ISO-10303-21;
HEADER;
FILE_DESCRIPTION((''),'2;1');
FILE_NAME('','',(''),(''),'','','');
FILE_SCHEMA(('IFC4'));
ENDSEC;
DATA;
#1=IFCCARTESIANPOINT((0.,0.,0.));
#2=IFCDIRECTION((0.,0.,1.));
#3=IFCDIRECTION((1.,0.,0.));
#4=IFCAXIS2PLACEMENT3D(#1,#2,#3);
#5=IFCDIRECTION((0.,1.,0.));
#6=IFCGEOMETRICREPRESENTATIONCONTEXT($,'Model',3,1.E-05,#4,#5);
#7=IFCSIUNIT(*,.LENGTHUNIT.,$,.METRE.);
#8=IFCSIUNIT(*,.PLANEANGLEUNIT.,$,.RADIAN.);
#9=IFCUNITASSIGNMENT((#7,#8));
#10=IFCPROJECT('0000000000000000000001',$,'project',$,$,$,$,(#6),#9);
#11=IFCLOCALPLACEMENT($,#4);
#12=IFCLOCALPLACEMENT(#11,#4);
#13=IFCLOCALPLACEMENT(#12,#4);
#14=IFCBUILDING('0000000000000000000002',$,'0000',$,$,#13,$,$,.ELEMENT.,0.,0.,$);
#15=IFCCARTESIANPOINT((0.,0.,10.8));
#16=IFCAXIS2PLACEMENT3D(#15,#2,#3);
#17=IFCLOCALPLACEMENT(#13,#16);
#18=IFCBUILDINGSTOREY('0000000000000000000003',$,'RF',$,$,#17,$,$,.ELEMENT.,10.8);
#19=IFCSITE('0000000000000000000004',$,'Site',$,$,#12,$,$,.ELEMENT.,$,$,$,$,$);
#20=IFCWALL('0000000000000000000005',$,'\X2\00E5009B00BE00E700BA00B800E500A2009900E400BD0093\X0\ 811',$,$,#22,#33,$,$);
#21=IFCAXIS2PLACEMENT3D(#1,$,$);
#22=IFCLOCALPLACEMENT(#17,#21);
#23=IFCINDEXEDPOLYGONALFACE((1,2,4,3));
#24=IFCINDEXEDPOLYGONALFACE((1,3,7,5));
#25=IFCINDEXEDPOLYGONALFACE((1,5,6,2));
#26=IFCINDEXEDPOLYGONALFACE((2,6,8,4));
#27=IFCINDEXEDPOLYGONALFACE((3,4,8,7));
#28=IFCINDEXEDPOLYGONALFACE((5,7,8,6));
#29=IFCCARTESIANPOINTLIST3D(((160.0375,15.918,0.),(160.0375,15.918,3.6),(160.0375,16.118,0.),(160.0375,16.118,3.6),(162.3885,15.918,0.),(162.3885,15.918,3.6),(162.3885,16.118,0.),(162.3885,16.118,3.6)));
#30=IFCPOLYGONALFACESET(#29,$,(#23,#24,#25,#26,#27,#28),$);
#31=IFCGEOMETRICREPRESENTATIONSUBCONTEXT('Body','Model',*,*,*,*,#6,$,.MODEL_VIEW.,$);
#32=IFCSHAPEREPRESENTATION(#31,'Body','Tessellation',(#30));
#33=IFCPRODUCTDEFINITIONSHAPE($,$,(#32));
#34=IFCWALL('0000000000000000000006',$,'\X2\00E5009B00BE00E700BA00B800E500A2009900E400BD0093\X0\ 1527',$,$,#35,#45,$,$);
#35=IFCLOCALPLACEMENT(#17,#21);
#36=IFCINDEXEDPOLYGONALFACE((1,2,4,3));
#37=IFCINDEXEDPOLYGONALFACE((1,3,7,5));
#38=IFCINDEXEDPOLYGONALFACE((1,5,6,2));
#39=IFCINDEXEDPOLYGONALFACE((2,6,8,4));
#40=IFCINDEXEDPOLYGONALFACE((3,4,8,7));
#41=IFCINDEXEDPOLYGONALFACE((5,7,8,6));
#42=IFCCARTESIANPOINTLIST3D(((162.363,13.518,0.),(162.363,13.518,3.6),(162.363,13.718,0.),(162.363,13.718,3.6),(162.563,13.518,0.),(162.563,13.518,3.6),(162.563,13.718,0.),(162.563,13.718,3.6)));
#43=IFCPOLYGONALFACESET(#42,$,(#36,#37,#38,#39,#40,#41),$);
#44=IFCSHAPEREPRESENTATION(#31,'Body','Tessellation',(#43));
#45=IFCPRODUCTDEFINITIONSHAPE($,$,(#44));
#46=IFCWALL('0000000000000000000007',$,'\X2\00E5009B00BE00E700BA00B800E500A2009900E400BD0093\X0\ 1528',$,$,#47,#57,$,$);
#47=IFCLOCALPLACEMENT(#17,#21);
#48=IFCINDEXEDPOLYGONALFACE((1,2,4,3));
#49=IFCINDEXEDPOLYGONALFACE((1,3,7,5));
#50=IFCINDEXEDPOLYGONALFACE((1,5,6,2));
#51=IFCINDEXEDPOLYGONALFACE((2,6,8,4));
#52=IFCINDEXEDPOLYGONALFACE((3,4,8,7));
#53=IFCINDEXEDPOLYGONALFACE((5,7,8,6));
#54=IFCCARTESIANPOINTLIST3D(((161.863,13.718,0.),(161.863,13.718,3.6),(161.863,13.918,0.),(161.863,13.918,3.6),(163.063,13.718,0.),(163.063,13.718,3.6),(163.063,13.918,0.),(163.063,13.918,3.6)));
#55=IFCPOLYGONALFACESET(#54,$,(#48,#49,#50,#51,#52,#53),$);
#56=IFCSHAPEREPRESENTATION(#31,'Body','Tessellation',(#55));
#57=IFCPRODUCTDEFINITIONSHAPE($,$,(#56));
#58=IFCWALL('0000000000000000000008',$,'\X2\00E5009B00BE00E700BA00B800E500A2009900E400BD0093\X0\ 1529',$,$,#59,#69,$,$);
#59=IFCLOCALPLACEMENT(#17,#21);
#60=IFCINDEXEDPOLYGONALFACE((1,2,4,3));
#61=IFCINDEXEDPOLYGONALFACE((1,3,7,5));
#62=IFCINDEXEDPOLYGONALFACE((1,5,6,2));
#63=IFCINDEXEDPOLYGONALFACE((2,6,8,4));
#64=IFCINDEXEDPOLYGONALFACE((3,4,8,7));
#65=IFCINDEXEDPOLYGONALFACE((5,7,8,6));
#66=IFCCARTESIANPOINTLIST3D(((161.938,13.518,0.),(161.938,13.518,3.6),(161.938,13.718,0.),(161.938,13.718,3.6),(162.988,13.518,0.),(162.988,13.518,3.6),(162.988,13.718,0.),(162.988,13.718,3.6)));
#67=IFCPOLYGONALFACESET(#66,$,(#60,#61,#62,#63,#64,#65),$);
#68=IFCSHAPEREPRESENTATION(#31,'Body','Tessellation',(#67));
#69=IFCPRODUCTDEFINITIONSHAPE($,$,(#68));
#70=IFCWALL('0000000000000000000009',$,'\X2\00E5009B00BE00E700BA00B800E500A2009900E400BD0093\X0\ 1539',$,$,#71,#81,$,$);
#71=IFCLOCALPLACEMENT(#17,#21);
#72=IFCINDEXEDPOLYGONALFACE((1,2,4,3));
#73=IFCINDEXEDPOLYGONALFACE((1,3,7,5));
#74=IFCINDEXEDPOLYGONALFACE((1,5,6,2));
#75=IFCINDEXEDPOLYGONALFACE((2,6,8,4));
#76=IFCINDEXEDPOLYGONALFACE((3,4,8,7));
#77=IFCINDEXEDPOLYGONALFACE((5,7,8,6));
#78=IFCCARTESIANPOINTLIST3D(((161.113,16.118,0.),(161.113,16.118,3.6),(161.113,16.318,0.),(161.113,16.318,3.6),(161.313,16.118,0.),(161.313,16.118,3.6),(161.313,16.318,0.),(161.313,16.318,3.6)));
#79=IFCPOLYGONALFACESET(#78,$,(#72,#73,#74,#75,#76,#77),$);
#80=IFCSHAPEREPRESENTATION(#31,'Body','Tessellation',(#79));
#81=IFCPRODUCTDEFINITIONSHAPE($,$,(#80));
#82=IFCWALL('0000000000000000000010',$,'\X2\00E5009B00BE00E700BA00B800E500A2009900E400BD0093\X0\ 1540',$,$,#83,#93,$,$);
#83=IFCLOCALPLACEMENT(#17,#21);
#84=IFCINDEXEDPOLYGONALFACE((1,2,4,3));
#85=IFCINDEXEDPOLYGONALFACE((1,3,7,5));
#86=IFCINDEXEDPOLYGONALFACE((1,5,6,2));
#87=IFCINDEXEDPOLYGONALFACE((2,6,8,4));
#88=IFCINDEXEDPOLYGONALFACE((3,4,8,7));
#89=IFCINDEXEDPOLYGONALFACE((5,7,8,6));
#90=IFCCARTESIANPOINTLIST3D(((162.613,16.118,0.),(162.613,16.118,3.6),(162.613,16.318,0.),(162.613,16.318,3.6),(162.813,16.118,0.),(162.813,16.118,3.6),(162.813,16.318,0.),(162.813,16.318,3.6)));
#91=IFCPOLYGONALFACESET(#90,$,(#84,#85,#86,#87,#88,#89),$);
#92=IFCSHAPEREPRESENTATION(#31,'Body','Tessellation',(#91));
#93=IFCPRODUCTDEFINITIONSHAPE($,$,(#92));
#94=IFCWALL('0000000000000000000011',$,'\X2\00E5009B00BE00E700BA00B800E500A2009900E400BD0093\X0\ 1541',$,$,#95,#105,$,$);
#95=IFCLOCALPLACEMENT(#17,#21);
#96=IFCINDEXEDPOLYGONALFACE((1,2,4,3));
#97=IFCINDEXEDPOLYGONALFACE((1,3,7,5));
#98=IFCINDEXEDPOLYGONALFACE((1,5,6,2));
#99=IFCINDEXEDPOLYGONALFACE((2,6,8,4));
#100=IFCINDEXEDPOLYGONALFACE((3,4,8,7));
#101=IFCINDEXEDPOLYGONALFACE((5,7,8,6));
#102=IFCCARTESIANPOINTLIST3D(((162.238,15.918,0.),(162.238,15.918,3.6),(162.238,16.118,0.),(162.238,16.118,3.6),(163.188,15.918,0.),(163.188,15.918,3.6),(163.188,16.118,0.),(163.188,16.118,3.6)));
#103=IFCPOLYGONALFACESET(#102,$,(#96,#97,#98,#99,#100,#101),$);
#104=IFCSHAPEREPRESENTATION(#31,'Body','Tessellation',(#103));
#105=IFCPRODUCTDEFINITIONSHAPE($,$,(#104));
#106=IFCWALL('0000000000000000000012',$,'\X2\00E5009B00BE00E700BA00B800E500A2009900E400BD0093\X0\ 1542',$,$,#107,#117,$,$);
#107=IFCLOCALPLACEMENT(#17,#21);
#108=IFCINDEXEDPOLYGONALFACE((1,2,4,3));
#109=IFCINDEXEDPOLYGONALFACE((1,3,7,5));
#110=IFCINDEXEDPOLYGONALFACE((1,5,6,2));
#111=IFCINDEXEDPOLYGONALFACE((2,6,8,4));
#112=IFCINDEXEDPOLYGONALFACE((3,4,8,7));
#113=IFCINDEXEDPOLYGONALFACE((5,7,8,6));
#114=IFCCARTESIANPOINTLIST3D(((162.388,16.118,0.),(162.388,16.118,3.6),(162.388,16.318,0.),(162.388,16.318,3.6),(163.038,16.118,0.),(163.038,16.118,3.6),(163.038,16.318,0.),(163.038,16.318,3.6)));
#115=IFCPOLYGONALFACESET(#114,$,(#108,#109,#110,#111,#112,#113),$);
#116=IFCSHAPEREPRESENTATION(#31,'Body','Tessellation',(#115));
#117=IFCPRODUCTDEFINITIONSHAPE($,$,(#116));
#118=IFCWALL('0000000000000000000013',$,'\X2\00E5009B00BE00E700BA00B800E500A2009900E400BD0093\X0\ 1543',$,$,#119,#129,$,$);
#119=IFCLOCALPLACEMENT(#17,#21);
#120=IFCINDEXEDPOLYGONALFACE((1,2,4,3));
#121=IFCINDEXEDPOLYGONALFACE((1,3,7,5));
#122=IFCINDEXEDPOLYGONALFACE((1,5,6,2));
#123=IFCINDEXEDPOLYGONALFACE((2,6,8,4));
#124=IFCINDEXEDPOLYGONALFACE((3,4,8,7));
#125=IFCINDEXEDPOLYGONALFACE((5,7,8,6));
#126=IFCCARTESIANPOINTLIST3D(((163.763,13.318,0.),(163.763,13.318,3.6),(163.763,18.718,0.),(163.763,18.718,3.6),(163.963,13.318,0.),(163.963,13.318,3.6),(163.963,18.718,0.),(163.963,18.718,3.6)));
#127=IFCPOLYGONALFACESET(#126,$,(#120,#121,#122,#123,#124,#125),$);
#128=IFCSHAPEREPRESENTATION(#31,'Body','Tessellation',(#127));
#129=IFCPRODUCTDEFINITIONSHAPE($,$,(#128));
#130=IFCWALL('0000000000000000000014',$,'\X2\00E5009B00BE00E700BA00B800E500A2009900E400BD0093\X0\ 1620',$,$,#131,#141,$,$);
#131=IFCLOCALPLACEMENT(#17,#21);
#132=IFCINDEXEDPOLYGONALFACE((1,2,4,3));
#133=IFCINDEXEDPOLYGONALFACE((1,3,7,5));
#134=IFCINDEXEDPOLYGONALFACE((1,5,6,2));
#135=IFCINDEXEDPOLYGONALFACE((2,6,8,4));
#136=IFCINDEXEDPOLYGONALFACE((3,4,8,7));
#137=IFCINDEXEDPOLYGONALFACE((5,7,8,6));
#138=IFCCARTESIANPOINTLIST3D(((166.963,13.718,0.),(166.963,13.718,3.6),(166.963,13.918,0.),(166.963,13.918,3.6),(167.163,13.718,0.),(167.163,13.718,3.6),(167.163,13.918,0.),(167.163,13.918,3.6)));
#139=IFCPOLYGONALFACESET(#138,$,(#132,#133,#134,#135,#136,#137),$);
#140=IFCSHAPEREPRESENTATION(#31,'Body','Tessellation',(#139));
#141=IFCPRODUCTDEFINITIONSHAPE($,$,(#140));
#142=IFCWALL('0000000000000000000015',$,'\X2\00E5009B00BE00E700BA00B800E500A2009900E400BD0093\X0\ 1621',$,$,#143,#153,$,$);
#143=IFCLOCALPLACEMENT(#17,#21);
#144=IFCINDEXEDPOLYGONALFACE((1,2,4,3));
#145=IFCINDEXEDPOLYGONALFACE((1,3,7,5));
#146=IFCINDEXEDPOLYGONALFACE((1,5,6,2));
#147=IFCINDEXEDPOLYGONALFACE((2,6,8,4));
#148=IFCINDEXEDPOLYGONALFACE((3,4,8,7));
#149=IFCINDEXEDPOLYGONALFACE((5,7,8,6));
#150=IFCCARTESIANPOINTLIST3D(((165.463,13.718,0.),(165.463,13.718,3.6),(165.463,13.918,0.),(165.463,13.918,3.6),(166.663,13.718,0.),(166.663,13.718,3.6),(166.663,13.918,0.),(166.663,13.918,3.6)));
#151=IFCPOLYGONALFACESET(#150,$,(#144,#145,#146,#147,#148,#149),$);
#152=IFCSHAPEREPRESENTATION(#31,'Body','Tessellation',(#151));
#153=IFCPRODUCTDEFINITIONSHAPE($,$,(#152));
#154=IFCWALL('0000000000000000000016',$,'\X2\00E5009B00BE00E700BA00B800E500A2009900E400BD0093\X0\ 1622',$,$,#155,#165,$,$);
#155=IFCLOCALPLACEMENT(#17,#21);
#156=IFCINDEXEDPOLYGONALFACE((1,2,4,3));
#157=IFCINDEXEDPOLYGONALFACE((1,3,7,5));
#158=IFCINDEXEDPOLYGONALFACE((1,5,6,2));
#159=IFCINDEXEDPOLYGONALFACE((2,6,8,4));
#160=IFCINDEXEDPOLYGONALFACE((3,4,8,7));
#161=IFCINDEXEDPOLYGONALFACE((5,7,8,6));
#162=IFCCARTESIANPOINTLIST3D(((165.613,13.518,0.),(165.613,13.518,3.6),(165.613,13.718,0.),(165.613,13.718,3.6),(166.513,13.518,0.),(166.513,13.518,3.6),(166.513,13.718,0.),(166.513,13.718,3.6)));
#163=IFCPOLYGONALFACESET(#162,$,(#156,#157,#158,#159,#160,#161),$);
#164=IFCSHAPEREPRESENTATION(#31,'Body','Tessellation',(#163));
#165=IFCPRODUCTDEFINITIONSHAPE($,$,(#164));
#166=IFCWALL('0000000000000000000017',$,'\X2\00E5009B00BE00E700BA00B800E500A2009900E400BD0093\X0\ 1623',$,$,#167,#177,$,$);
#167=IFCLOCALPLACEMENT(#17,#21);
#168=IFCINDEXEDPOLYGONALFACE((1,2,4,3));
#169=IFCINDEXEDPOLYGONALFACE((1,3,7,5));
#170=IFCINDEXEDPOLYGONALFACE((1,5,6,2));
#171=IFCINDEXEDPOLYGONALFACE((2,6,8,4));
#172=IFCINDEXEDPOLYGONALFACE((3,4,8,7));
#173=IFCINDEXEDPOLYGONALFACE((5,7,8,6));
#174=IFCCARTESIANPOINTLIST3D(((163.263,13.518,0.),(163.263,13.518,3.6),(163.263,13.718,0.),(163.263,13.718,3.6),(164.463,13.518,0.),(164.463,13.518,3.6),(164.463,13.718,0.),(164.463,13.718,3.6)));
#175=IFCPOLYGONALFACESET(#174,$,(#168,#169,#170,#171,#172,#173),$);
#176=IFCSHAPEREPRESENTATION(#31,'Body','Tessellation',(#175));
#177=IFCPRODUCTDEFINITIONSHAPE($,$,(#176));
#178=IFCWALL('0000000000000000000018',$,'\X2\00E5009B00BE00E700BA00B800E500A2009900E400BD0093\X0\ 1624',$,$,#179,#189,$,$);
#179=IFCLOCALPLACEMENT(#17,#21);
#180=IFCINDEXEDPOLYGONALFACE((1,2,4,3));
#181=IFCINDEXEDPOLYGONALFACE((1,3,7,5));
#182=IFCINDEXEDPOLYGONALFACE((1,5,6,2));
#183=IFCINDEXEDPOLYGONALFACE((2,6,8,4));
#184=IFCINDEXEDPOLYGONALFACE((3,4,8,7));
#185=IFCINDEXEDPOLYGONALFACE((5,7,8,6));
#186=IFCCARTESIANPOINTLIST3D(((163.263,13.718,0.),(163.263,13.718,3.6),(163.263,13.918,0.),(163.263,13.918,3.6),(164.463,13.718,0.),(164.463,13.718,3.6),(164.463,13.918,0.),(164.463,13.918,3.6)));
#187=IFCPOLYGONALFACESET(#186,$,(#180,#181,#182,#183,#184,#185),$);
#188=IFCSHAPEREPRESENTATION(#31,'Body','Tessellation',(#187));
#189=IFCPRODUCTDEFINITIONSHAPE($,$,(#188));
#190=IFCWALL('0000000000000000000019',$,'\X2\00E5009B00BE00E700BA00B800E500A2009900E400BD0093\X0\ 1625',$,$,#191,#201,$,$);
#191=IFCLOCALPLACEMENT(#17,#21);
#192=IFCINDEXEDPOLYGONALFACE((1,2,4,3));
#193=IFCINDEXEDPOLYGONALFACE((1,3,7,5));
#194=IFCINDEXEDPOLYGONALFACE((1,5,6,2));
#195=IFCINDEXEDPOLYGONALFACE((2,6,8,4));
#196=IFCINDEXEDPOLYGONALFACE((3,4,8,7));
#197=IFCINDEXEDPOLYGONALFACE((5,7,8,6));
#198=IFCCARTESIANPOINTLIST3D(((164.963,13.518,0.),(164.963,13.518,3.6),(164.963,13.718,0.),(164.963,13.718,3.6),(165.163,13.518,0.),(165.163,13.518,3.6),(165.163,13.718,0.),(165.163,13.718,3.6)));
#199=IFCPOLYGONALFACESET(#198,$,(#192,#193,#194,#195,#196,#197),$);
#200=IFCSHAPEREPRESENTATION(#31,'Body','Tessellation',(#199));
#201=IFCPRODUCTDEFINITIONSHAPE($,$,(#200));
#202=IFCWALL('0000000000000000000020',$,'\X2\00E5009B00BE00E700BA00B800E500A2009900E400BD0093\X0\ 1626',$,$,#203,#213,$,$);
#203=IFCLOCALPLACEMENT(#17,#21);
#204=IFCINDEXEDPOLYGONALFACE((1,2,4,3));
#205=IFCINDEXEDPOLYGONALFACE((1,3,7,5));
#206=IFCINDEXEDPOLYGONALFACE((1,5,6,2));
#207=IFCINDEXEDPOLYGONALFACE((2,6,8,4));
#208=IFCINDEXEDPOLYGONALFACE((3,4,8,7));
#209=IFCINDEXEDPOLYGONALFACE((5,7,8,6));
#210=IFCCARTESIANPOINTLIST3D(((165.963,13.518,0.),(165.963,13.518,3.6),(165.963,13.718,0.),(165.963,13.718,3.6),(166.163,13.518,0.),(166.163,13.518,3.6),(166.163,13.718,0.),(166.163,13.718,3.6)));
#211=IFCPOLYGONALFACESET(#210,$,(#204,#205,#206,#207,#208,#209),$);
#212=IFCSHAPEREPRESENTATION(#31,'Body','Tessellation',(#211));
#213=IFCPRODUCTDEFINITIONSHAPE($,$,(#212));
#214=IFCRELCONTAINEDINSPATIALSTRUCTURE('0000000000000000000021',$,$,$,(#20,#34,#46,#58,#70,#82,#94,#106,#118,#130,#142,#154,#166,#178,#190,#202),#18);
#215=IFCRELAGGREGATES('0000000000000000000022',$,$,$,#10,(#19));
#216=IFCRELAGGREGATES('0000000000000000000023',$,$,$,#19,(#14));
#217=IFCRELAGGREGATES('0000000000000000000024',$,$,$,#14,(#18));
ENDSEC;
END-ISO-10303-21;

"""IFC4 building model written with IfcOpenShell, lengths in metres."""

from ifc_helpers import new_model, si_unit, direction, frame, frame_2d, origin_with_axes, place, context, subcontext, project, spatial, rectangle, extrude, element, save


model = new_model("IFC4")

# Units and contexts
model_context = context("Model", 3, precision=1e-05, world=origin_with_axes(), true_north=direction((0.0, 1.0, 0.0)))
body_context = subcontext(model_context, "Body", "Model", "MODEL_VIEW")
ifc_project = project(units=[si_unit("LENGTHUNIT", "METRE"), si_unit("PLANEANGLEUNIT", "RADIAN")], contexts=[model_context])

# Site, building, storey
placement = place(None, origin_with_axes())
site_placement = place(placement, origin_with_axes())
site = spatial("IfcSite", under=ifc_project, at=site_placement, Name="Site", CompositionType="ELEMENT")
building_placement = place(site_placement, origin_with_axes())
building = spatial("IfcBuilding", under=site, at=building_placement, Name="0000", CompositionType="ELEMENT", ElevationOfRefHeight=0.0, ElevationOfTerrain=0.0)
storey_placement = place(building_placement, frame((0.0, 0.0, 10.8), z_axis=(0.0, 0.0, 1.0), x_axis=(1.0, 0.0, 0.0)))
storey = spatial("IfcBuildingStorey", under=building, at=storey_placement, Name="RF", CompositionType="ELEMENT", Elevation=10.8)

# Walls
wall_1_placement = place(storey_placement, frame((161.213, 16.018, 0.0), z_axis=(0.0, 0.0, 1.0), x_axis=(-1.0, 0.0, 0.0)))
element("IfcWall", 1, at=wall_1_placement, inside=storey, Name="å\u009b¾çº¸å¢\u0099ä½\u0093 811", context=body_context, shape_type="SweptSolid", body=[
    extrude(rectangle(XDim=2.351, YDim=0.2, at=frame_2d((0.0, 0.0), x_axis=(1.0, 0.0, 0.0))), frame((0.0, 0.0, 0.0), z_axis=(0.0, 0.0, 1.0)), (0.0, 0.0, 1.0), 3.6),
])
wall_2_placement = place(storey_placement, frame((162.463, 13.618, 0.0), z_axis=(0.0, 0.0, 1.0), x_axis=(0.0, 1.0, 0.0)))
element("IfcWall", 2, at=wall_2_placement, inside=storey, Name="å\u009b¾çº¸å¢\u0099ä½\u0093 1527", context=body_context, shape_type="SweptSolid", body=[
    extrude(rectangle(XDim=0.2, YDim=0.2, at=frame_2d((0.0, 0.0), x_axis=(1.0, 0.0, 0.0))), frame((0.0, 0.0, 0.0), z_axis=(0.0, 0.0, 1.0)), (0.0, 0.0, 1.0), 3.6),
])
wall_3_placement = place(storey_placement, frame((162.463, 13.818, 0.0), z_axis=(0.0, 0.0, 1.0), x_axis=(1.0, 0.0, 0.0)))
element("IfcWall", 3, at=wall_3_placement, inside=storey, Name="å\u009b¾çº¸å¢\u0099ä½\u0093 1528", context=body_context, shape_type="SweptSolid", body=[
    extrude(rectangle(XDim=1.2, YDim=0.2, at=frame_2d((0.0, 0.0), x_axis=(1.0, 0.0, 0.0))), frame((0.0, 0.0, 0.0), z_axis=(0.0, 0.0, 1.0)), (0.0, 0.0, 1.0), 3.6),
])
wall_4_placement = place(storey_placement, frame((162.463, 13.618, 0.0), z_axis=(0.0, 0.0, 1.0), x_axis=(1.0, 0.0, 0.0)))
element("IfcWall", 4, at=wall_4_placement, inside=storey, Name="å\u009b¾çº¸å¢\u0099ä½\u0093 1529", context=body_context, shape_type="SweptSolid", body=[
    extrude(rectangle(XDim=1.05, YDim=0.2, at=frame_2d((0.0, 0.0), x_axis=(1.0, 0.0, 0.0))), frame((0.0, 0.0, 0.0), z_axis=(0.0, 0.0, 1.0)), (0.0, 0.0, 1.0), 3.6),
])
for number, where, z_axis, x_axis, name in (
    (5, (161.213, 16.218, 0.0), (0.0, 0.0, 1.0), (0.0, -1.0, 0.0), "å\u009b¾çº¸å¢\u0099ä½\u0093 1539"),
    (6, (162.713, 16.218, 0.0), (0.0, 0.0, 1.0), (0.0, -1.0, 0.0), "å\u009b¾çº¸å¢\u0099ä½\u0093 1540"),
):
    element("IfcWall", number, at=place(storey_placement, frame(where, z_axis=z_axis, x_axis=x_axis)), inside=storey, Name=name, context=body_context, shape_type="SweptSolid", body=[
        extrude(rectangle(XDim=0.2, YDim=0.2, at=frame_2d((0.0, 0.0), x_axis=(1.0, 0.0, 0.0))), frame((0.0, 0.0, 0.0), z_axis=(0.0, 0.0, 1.0)), (0.0, 0.0, 1.0), 3.6),
    ])
wall_5_placement = place(storey_placement, frame((162.713, 16.018, 0.0), z_axis=(0.0, 0.0, 1.0), x_axis=(1.0, 0.0, 0.0)))
element("IfcWall", 7, at=wall_5_placement, inside=storey, Name="å\u009b¾çº¸å¢\u0099ä½\u0093 1541", context=body_context, shape_type="SweptSolid", body=[
    extrude(rectangle(XDim=0.95, YDim=0.2, at=frame_2d((0.0, 0.0), x_axis=(1.0, 0.0, 0.0))), frame((0.0, 0.0, 0.0), z_axis=(0.0, 0.0, 1.0)), (0.0, 0.0, 1.0), 3.6),
])
wall_6_placement = place(storey_placement, frame((162.713, 16.218, 0.0), z_axis=(0.0, 0.0, 1.0), x_axis=(1.0, 0.0, 0.0)))
element("IfcWall", 8, at=wall_6_placement, inside=storey, Name="å\u009b¾çº¸å¢\u0099ä½\u0093 1542", context=body_context, shape_type="SweptSolid", body=[
    extrude(rectangle(XDim=0.65, YDim=0.2, at=frame_2d((0.0, 0.0), x_axis=(1.0, 0.0, 0.0))), frame((0.0, 0.0, 0.0), z_axis=(0.0, 0.0, 1.0)), (0.0, 0.0, 1.0), 3.6),
])
wall_7_placement = place(storey_placement, frame((163.863, 16.018, 0.0), z_axis=(0.0, 0.0, 1.0), x_axis=(0.0, 1.0, 0.0)))
element("IfcWall", 9, at=wall_7_placement, inside=storey, Name="å\u009b¾çº¸å¢\u0099ä½\u0093 1543", context=body_context, shape_type="SweptSolid", body=[
    extrude(rectangle(XDim=5.4, YDim=0.2, at=frame_2d((0.0, 0.0), x_axis=(1.0, 0.0, 0.0))), frame((0.0, 0.0, 0.0), z_axis=(0.0, 0.0, 1.0)), (0.0, 0.0, 1.0), 3.6),
])
wall_8_placement = place(storey_placement, frame((167.063, 13.818, 0.0), z_axis=(0.0, 0.0, 1.0), x_axis=(-1.0, 0.0, 0.0)))
element("IfcWall", 10, at=wall_8_placement, inside=storey, Name="å\u009b¾çº¸å¢\u0099ä½\u0093 1620", context=body_context, shape_type="SweptSolid", body=[
    extrude(rectangle(XDim=0.2, YDim=0.2, at=frame_2d((0.0, 0.0), x_axis=(1.0, 0.0, 0.0))), frame((0.0, 0.0, 0.0), z_axis=(0.0, 0.0, 1.0)), (0.0, 0.0, 1.0), 3.6),
])
wall_9_placement = place(storey_placement, frame((166.063, 13.818, 0.0), z_axis=(0.0, 0.0, 1.0), x_axis=(1.0, 0.0, 0.0)))
element("IfcWall", 11, at=wall_9_placement, inside=storey, Name="å\u009b¾çº¸å¢\u0099ä½\u0093 1621", context=body_context, shape_type="SweptSolid", body=[
    extrude(rectangle(XDim=1.2, YDim=0.2, at=frame_2d((0.0, 0.0), x_axis=(1.0, 0.0, 0.0))), frame((0.0, 0.0, 0.0), z_axis=(0.0, 0.0, 1.0)), (0.0, 0.0, 1.0), 3.6),
])
wall_10_placement = place(storey_placement, frame((166.063, 13.618, 0.0), z_axis=(0.0, 0.0, 1.0), x_axis=(1.0, 0.0, 0.0)))
element("IfcWall", 12, at=wall_10_placement, inside=storey, Name="å\u009b¾çº¸å¢\u0099ä½\u0093 1622", context=body_context, shape_type="SweptSolid", body=[
    extrude(rectangle(XDim=0.9, YDim=0.2, at=frame_2d((0.0, 0.0), x_axis=(1.0, 0.0, 0.0))), frame((0.0, 0.0, 0.0), z_axis=(0.0, 0.0, 1.0)), (0.0, 0.0, 1.0), 3.6),
])
for number, where, z_axis, x_axis, name in (
    (13, (163.863, 13.618, 0.0), (0.0, 0.0, 1.0), (1.0, 0.0, 0.0), "å\u009b¾çº¸å¢\u0099ä½\u0093 1623"),
    (14, (163.863, 13.818, 0.0), (0.0, 0.0, 1.0), (1.0, 0.0, 0.0), "å\u009b¾çº¸å¢\u0099ä½\u0093 1624"),
):
    element("IfcWall", number, at=place(storey_placement, frame(where, z_axis=z_axis, x_axis=x_axis)), inside=storey, Name=name, context=body_context, shape_type="SweptSolid", body=[
        extrude(rectangle(XDim=1.2, YDim=0.2, at=frame_2d((0.0, 0.0), x_axis=(1.0, 0.0, 0.0))), frame((0.0, 0.0, 0.0), z_axis=(0.0, 0.0, 1.0)), (0.0, 0.0, 1.0), 3.6),
    ])
for number, where, z_axis, x_axis, name in (
    (15, (165.063, 13.618, 0.0), (0.0, 0.0, 1.0), (0.0, 1.0, 0.0), "å\u009b¾çº¸å¢\u0099ä½\u0093 1625"),
    (16, (166.063, 13.618, 0.0), (0.0, 0.0, 1.0), (0.0, 1.0, 0.0), "å\u009b¾çº¸å¢\u0099ä½\u0093 1626"),
):
    element("IfcWall", number, at=place(storey_placement, frame(where, z_axis=z_axis, x_axis=x_axis)), inside=storey, Name=name, context=body_context, shape_type="SweptSolid", body=[
        extrude(rectangle(XDim=0.2, YDim=0.2, at=frame_2d((0.0, 0.0), x_axis=(1.0, 0.0, 0.0))), frame((0.0, 0.0, 0.0), z_axis=(0.0, 0.0, 1.0)), (0.0, 0.0, 1.0), 3.6),
    ])

save(model, "model.ifc")
